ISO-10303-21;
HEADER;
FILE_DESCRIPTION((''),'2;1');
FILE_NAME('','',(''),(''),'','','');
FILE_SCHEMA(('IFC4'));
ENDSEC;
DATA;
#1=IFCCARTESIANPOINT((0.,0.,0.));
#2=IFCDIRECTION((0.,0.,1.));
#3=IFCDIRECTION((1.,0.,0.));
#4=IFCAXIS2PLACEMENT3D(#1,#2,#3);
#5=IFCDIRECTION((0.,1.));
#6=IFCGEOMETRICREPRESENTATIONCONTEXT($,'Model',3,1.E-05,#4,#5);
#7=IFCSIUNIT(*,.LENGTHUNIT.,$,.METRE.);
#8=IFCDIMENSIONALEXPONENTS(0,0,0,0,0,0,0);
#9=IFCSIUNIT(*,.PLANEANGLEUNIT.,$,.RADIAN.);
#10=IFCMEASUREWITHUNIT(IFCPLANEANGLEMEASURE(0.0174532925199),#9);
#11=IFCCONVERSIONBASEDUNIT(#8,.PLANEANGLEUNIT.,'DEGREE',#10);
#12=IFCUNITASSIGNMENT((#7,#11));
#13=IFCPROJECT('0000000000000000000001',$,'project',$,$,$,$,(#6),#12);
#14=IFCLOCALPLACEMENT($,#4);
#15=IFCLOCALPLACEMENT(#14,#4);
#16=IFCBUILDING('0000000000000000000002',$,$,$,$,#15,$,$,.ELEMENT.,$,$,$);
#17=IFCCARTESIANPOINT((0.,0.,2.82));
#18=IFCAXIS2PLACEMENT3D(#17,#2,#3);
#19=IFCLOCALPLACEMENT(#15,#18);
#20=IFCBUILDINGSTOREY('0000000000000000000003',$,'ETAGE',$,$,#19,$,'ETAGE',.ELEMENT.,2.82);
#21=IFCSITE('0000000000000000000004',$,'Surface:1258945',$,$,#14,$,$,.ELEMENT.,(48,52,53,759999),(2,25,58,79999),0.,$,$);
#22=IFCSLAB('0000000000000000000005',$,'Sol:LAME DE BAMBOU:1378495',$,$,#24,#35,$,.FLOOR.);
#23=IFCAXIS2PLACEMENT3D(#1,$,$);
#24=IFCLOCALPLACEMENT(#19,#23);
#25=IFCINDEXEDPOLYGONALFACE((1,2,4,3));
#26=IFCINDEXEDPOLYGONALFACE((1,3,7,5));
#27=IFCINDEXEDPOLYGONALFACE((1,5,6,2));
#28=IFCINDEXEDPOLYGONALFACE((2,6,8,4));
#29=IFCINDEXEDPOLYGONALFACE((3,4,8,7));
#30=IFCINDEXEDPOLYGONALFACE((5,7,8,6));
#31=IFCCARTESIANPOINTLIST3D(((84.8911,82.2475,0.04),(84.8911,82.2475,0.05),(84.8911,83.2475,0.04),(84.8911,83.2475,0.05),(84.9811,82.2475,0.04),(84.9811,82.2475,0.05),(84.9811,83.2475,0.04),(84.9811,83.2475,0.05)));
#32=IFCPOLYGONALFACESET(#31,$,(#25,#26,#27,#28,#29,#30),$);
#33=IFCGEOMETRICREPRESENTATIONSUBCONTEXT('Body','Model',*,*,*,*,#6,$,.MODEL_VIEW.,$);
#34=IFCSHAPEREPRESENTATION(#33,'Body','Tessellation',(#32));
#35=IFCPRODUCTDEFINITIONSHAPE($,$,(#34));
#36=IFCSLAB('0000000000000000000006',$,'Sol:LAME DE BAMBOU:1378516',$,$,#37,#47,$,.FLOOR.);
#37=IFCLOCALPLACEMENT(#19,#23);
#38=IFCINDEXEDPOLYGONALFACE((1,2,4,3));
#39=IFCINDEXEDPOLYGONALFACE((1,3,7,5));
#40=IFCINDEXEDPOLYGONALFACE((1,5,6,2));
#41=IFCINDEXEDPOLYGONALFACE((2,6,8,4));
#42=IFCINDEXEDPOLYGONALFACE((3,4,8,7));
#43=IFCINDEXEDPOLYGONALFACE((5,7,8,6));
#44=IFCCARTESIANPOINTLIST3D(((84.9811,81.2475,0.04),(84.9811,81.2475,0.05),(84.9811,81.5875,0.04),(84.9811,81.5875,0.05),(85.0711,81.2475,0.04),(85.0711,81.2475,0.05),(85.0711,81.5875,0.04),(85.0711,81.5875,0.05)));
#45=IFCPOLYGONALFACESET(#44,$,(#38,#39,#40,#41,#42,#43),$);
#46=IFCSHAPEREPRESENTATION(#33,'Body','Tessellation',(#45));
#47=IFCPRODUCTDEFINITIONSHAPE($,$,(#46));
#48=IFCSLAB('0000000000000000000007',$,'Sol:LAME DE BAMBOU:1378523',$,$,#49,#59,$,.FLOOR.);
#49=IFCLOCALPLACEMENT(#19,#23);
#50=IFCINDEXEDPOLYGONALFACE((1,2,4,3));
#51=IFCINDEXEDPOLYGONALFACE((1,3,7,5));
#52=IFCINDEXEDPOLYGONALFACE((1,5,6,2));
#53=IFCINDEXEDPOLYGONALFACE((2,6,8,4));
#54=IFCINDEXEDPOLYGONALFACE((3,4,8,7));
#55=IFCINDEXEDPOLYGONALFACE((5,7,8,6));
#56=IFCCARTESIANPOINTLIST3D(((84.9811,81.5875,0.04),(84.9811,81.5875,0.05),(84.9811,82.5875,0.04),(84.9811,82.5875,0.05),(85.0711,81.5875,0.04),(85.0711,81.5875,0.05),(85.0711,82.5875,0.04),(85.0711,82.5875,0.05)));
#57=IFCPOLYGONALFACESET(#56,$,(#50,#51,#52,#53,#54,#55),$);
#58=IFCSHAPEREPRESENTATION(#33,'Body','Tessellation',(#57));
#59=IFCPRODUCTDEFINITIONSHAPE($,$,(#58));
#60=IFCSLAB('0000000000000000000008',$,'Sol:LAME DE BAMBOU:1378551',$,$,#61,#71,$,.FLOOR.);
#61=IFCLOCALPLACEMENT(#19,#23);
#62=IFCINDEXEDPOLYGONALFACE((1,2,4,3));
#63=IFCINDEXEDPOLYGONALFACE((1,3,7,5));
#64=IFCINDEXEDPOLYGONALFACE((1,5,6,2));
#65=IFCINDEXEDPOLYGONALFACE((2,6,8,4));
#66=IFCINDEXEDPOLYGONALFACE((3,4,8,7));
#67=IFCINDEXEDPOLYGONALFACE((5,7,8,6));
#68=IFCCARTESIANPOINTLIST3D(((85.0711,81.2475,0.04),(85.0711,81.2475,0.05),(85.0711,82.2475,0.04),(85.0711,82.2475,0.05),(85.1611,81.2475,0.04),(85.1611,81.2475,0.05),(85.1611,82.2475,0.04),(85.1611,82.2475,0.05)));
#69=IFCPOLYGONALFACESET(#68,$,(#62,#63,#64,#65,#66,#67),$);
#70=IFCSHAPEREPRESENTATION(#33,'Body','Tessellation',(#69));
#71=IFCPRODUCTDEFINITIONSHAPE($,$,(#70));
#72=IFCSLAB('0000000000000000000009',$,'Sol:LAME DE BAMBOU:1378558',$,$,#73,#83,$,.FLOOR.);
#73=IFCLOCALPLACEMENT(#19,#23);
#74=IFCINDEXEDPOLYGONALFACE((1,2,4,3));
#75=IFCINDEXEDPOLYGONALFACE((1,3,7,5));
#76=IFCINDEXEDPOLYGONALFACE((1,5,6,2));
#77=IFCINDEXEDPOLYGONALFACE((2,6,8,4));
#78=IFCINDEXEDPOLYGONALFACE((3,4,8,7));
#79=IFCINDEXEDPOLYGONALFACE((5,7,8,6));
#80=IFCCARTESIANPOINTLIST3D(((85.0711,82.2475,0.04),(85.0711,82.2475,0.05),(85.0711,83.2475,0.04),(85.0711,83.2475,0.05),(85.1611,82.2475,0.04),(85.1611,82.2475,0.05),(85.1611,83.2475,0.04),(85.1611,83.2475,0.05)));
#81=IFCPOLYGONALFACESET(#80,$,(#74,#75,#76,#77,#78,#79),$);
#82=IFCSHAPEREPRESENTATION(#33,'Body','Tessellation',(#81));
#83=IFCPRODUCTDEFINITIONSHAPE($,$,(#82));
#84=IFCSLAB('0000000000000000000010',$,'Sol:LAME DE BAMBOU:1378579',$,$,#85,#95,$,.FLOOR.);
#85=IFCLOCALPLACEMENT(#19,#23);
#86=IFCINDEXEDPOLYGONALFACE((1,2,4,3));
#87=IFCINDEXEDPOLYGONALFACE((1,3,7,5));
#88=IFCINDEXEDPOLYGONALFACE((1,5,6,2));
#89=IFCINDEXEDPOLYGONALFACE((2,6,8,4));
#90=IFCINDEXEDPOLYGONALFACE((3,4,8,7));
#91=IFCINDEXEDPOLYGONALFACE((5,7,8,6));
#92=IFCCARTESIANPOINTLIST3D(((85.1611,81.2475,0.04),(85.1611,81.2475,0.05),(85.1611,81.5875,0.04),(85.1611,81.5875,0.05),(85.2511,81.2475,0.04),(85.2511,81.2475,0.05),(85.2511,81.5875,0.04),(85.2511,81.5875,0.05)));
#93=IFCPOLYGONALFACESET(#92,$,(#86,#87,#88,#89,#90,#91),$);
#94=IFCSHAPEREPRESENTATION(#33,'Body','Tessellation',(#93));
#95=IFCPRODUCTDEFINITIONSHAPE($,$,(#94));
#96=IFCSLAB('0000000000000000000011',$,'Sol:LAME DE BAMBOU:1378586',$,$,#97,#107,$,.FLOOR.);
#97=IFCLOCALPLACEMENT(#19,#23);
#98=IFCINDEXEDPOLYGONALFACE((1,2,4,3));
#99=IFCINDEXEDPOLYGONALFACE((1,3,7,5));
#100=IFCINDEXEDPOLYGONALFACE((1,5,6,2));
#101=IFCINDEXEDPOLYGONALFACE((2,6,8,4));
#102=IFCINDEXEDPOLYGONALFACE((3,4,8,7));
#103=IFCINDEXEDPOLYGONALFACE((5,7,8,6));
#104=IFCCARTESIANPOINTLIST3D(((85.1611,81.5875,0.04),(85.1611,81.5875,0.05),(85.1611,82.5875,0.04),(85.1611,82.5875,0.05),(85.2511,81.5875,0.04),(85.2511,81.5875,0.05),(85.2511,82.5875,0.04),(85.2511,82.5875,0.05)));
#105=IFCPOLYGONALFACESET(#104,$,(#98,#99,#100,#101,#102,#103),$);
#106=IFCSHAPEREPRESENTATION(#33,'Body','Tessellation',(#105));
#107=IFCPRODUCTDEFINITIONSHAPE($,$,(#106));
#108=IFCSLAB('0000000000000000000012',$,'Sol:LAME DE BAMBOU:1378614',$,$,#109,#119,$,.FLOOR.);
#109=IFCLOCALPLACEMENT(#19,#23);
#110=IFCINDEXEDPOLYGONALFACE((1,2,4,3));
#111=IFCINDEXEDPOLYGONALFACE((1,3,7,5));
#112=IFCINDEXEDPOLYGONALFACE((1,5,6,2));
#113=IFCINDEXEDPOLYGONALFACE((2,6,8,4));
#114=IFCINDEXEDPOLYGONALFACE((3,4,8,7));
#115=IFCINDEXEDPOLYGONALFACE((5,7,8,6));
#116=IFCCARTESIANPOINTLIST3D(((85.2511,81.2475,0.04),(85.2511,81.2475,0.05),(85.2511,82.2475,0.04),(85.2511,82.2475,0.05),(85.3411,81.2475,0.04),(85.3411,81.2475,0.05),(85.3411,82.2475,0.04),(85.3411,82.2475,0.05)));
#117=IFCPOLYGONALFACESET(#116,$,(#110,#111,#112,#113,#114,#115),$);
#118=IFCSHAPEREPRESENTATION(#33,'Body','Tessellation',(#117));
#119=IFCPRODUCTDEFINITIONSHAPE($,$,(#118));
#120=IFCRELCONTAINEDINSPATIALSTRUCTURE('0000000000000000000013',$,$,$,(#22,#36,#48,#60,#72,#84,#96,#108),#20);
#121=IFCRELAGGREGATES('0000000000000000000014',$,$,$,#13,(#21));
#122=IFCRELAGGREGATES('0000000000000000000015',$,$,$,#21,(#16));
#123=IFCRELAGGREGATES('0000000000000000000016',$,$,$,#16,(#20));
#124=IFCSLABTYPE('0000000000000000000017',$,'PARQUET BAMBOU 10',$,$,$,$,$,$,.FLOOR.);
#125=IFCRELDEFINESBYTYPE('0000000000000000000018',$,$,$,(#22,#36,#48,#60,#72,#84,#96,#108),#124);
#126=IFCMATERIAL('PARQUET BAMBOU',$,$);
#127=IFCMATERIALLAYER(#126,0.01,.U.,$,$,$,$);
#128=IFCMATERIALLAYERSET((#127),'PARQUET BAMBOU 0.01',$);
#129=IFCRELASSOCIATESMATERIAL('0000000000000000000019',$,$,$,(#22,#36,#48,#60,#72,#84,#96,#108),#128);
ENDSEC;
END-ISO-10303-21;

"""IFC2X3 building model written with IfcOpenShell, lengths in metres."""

from ifc_helpers import new_model, entity, si_unit, converted_unit, direction, frame, origin_with_axes, place, context, subcontext, project, spatial, polyline, outline, extrude, material, layer, layer_set, layer_usage, type_object, element, save


model = new_model("IFC2X3")

# Units and contexts
model_context = context("Model", 3, precision=1e-05, world=origin_with_axes(), true_north=direction((0.0, 1.0)))
body_context = subcontext(model_context, "Body", "Model", "MODEL_VIEW")
ifc_project = project(units=[si_unit("LENGTHUNIT", "METRE"), converted_unit("PLANEANGLEUNIT", "DEGREE", entity("IfcPlaneAngleMeasure", 0.0174532925199), si_unit("PLANEANGLEUNIT", "RADIAN"), dimensions=[0, 0, 0, 0, 0, 0, 0])], contexts=[model_context])

# Site, building, storey
site_placement = place(None, origin_with_axes())
site = spatial("IfcSite", under=ifc_project, at=site_placement, Name="Surface:1258945", CompositionType="ELEMENT", RefLatitude=(48, 52, 53, 759999), RefLongitude=(2, 25, 58, 79999), RefElevation=0.0)
building_placement = place(site_placement, origin_with_axes())
building = spatial("IfcBuilding", under=site, at=building_placement, CompositionType="ELEMENT")
storey_placement = place(building_placement, frame((0.0, 0.0, 2.82), z_axis=(0.0, 0.0, 1.0), x_axis=(1.0, 0.0, 0.0)))
storey = spatial("IfcBuildingStorey", under=building, at=storey_placement, Name="ETAGE", LongName="ETAGE", CompositionType="ELEMENT", Elevation=2.82)

# Slabs
ifc_material = material(Name="PARQUET BAMBOU")
ifc_layer = layer(ifc_material, 0.01, ventilated="UNKNOWN")
ifc_layer_set = layer_set([ifc_layer], Name="PARQUET BAMBOU 0.01")
slab_type = type_object("IfcSlabType", Name="PARQUET BAMBOU 10", PredefinedType="FLOOR")
ifc_layer_usage_1 = layer_usage(ifc_layer_set, "AXIS3", "NEGATIVE", 0.01)
slab_1_placement = place(storey_placement, frame((84.8911, 83.2475, 0.05), z_axis=(0.0, 0.0, 1.0), x_axis=(1.0, 0.0, 0.0)))
element("IfcSlab", 1, at=slab_1_placement, inside=storey, type_object=slab_type, material=ifc_layer_usage_1, Name="Sol:LAME DE BAMBOU:1378495", PredefinedType="FLOOR", context=body_context, shape_type="SweptSolid", body=[
    extrude(outline(polyline([(0.0, 0.0), (0.0, -1.0), (0.09, -1.0), (0.09, 0.0), (0.0, 0.0)])), frame((0.0, 0.0, -0.01), z_axis=(0.0, 0.0, 1.0), x_axis=(1.0, 0.0, 0.0)), (0.0, 0.0, 1.0), 0.01),
])
ifc_layer_usage_2 = layer_usage(ifc_layer_set, "AXIS3", "NEGATIVE", 0.01)
slab_2_placement = place(storey_placement, frame((84.9811, 81.5875, 0.05), z_axis=(0.0, 0.0, 1.0), x_axis=(1.0, 0.0, 0.0)))
element("IfcSlab", 2, at=slab_2_placement, inside=storey, type_object=slab_type, material=ifc_layer_usage_2, Name="Sol:LAME DE BAMBOU:1378516", PredefinedType="FLOOR", context=body_context, shape_type="SweptSolid", body=[
    extrude(outline(polyline([(0.0, 0.0), (0.0, -0.34), (0.09, -0.34), (0.09, 0.0), (0.0, 0.0)])), frame((0.0, 0.0, -0.01), z_axis=(0.0, 0.0, 1.0), x_axis=(1.0, 0.0, 0.0)), (0.0, 0.0, 1.0), 0.01),
])
ifc_layer_usage_3 = layer_usage(ifc_layer_set, "AXIS3", "NEGATIVE", 0.01)
slab_3_placement = place(storey_placement, frame((84.9811, 82.5875, 0.05), z_axis=(0.0, 0.0, 1.0), x_axis=(1.0, 0.0, 0.0)))
element("IfcSlab", 3, at=slab_3_placement, inside=storey, type_object=slab_type, material=ifc_layer_usage_3, Name="Sol:LAME DE BAMBOU:1378523", PredefinedType="FLOOR", context=body_context, shape_type="SweptSolid", body=[
    extrude(outline(polyline([(0.0, 0.0), (0.0, -1.0), (0.09, -1.0), (0.09, 0.0), (0.0, 0.0)])), frame((0.0, 0.0, -0.01), z_axis=(0.0, 0.0, 1.0), x_axis=(1.0, 0.0, 0.0)), (0.0, 0.0, 1.0), 0.01),
])
ifc_layer_usage_4 = layer_usage(ifc_layer_set, "AXIS3", "NEGATIVE", 0.01)
slab_4_placement = place(storey_placement, frame((85.0711, 82.2475, 0.05), z_axis=(0.0, 0.0, 1.0), x_axis=(1.0, 0.0, 0.0)))
element("IfcSlab", 4, at=slab_4_placement, inside=storey, type_object=slab_type, material=ifc_layer_usage_4, Name="Sol:LAME DE BAMBOU:1378551", PredefinedType="FLOOR", context=body_context, shape_type="SweptSolid", body=[
    extrude(outline(polyline([(0.0, 0.0), (0.0, -1.0), (0.09, -1.0), (0.09, 0.0), (0.0, 0.0)])), frame((0.0, 0.0, -0.01), z_axis=(0.0, 0.0, 1.0), x_axis=(1.0, 0.0, 0.0)), (0.0, 0.0, 1.0), 0.01),
])
ifc_layer_usage_5 = layer_usage(ifc_layer_set, "AXIS3", "NEGATIVE", 0.01)
slab_5_placement = place(storey_placement, frame((85.0711, 83.2475, 0.05), z_axis=(0.0, 0.0, 1.0), x_axis=(1.0, 0.0, 0.0)))
element("IfcSlab", 5, at=slab_5_placement, inside=storey, type_object=slab_type, material=ifc_layer_usage_5, Name="Sol:LAME DE BAMBOU:1378558", PredefinedType="FLOOR", context=body_context, shape_type="SweptSolid", body=[
    extrude(outline(polyline([(0.0, 0.0), (0.0, -1.0), (0.09, -1.0), (0.09, 0.0), (0.0, 0.0)])), frame((0.0, 0.0, -0.01), z_axis=(0.0, 0.0, 1.0), x_axis=(1.0, 0.0, 0.0)), (0.0, 0.0, 1.0), 0.01),
])
ifc_layer_usage_6 = layer_usage(ifc_layer_set, "AXIS3", "NEGATIVE", 0.01)
slab_6_placement = place(storey_placement, frame((85.1611, 81.5875, 0.05), z_axis=(0.0, 0.0, 1.0), x_axis=(1.0, 0.0, 0.0)))
element("IfcSlab", 6, at=slab_6_placement, inside=storey, type_object=slab_type, material=ifc_layer_usage_6, Name="Sol:LAME DE BAMBOU:1378579", PredefinedType="FLOOR", context=body_context, shape_type="SweptSolid", body=[
    extrude(outline(polyline([(0.0, 0.0), (0.0, -0.34), (0.09, -0.34), (0.09, 0.0), (0.0, 0.0)])), frame((0.0, 0.0, -0.01), z_axis=(0.0, 0.0, 1.0), x_axis=(1.0, 0.0, 0.0)), (0.0, 0.0, 1.0), 0.01),
])
ifc_layer_usage_7 = layer_usage(ifc_layer_set, "AXIS3", "NEGATIVE", 0.01)
slab_7_placement = place(storey_placement, frame((85.1611, 82.5875, 0.05), z_axis=(0.0, 0.0, 1.0), x_axis=(1.0, 0.0, 0.0)))
element("IfcSlab", 7, at=slab_7_placement, inside=storey, type_object=slab_type, material=ifc_layer_usage_7, Name="Sol:LAME DE BAMBOU:1378586", PredefinedType="FLOOR", context=body_context, shape_type="SweptSolid", body=[
    extrude(outline(polyline([(0.0, 0.0), (0.0, -1.0), (0.09, -1.0), (0.09, 0.0), (0.0, 0.0)])), frame((0.0, 0.0, -0.01), z_axis=(0.0, 0.0, 1.0), x_axis=(1.0, 0.0, 0.0)), (0.0, 0.0, 1.0), 0.01),
])
ifc_layer_usage_8 = layer_usage(ifc_layer_set, "AXIS3", "NEGATIVE", 0.01)
slab_8_placement = place(storey_placement, frame((85.2511, 82.2475, 0.05), z_axis=(0.0, 0.0, 1.0), x_axis=(1.0, 0.0, 0.0)))
element("IfcSlab", 8, at=slab_8_placement, inside=storey, type_object=slab_type, material=ifc_layer_usage_8, Name="Sol:LAME DE BAMBOU:1378614", PredefinedType="FLOOR", context=body_context, shape_type="SweptSolid", body=[
    extrude(outline(polyline([(0.0, 0.0), (0.0, -1.0), (0.09, -1.0), (0.09, 0.0), (0.0, 0.0)])), frame((0.0, 0.0, -0.01), z_axis=(0.0, 0.0, 1.0), x_axis=(1.0, 0.0, 0.0)), (0.0, 0.0, 1.0), 0.01),
])

save(model, "model.ifc")
